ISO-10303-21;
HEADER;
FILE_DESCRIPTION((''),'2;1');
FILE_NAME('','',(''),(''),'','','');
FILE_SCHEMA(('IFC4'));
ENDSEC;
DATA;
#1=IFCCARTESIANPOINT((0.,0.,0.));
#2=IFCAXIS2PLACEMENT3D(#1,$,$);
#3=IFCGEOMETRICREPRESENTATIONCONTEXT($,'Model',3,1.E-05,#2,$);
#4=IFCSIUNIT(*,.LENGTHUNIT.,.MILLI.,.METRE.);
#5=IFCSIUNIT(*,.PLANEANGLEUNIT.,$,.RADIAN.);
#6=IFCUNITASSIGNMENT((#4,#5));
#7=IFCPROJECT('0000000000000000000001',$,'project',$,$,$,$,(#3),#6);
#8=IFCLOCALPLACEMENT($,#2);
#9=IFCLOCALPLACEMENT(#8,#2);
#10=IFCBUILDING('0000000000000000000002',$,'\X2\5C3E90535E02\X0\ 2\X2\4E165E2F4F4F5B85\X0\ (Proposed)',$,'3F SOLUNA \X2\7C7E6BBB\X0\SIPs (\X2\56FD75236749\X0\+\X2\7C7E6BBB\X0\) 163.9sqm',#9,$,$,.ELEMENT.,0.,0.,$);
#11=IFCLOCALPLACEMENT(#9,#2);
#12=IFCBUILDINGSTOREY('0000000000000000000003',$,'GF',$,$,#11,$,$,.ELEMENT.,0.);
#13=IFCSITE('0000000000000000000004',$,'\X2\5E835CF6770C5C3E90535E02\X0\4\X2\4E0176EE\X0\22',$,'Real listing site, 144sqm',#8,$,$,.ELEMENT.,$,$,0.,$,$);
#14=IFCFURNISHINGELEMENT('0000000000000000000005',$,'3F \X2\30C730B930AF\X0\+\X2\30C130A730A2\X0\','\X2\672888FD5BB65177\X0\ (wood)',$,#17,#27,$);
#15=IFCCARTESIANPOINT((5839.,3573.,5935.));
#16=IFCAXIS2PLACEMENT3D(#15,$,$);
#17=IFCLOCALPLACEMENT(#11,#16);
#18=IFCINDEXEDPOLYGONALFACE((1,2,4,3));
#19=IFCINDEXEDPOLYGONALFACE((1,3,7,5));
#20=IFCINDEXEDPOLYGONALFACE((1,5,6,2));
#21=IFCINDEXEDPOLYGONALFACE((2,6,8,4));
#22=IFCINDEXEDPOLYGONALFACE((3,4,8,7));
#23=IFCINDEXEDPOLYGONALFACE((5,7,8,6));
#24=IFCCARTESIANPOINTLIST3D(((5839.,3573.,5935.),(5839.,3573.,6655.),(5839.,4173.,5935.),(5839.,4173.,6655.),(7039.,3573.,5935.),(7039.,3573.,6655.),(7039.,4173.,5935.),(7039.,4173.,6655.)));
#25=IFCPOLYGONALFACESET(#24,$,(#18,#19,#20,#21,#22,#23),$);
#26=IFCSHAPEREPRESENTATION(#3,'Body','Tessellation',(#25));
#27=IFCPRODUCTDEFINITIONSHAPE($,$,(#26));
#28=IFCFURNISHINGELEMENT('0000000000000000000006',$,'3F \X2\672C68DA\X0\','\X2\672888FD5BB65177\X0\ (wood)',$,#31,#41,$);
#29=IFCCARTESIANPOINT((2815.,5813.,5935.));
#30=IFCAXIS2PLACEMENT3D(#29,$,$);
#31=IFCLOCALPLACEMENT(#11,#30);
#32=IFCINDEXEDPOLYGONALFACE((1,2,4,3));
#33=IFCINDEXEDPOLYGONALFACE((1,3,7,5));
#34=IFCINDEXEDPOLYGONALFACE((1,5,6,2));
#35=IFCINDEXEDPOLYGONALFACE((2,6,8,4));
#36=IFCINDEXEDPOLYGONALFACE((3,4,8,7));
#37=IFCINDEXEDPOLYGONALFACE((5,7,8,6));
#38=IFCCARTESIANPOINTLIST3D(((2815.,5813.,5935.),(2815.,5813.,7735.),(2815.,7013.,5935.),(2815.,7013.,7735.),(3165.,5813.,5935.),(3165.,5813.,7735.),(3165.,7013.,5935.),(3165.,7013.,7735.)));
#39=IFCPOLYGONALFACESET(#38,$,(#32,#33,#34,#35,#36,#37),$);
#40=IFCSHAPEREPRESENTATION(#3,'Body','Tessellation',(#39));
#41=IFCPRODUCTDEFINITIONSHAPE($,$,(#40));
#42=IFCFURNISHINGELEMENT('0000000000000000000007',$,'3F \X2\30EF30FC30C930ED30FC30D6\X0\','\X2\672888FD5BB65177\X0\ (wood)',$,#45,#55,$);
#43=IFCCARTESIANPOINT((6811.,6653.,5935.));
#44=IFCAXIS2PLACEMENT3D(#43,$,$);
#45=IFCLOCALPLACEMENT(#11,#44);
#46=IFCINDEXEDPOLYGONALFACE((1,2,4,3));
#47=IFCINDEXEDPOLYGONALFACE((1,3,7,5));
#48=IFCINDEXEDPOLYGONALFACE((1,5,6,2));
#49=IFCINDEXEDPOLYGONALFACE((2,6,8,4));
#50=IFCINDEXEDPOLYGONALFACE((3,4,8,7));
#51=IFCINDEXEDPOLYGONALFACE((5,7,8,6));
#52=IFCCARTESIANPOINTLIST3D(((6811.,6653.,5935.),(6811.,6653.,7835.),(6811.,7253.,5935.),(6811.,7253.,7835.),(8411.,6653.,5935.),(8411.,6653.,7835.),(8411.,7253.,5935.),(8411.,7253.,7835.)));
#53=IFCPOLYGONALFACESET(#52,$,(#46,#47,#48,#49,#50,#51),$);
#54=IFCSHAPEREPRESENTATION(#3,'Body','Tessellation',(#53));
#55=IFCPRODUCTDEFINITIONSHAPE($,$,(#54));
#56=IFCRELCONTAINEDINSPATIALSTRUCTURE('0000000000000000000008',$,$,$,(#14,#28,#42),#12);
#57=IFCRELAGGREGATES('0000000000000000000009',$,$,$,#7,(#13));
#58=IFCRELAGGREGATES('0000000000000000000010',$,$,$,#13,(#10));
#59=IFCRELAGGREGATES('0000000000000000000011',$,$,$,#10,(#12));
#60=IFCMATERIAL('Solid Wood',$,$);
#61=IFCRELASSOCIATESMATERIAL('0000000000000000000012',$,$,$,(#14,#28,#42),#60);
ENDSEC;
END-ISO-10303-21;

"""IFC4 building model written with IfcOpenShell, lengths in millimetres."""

from ifc_helpers import new_model, si_unit, frame, frame_2d, origin, place, context, project, spatial, rectangle, extrude, material, element, save


model = new_model("IFC4")

# Units and contexts
model_context = context("Model", 3, precision=1e-05, world=origin())
ifc_project = project(units=[si_unit("LENGTHUNIT", "METRE", prefix="MILLI"), si_unit("PLANEANGLEUNIT", "RADIAN")], contexts=[model_context])

# Site, building, storey
site_placement = place(None, origin())
site = spatial("IfcSite", under=ifc_project, at=site_placement, Name="広島県尾道市4丁目22", ObjectType="Real listing site, 144sqm", CompositionType="ELEMENT", RefElevation=0.0)
building_placement = place(site_placement, origin())
building = spatial("IfcBuilding", under=site, at=building_placement, Name="尾道市 2世帯住宅 (Proposed)", ObjectType="3F SOLUNA 籾殻SIPs (国産杉+籾殻) 163.9sqm", CompositionType="ELEMENT", ElevationOfRefHeight=0.0, ElevationOfTerrain=0.0)
storey_placement = place(building_placement, origin())
storey = spatial("IfcBuildingStorey", under=building, at=storey_placement, Name="GF", CompositionType="ELEMENT", Elevation=0.0)

# Shared definitions
ifc_material_1 = material(Name="Solid Wood")

# Furnishing elements
furnishing_1_placement = place(storey_placement, frame((5839.0, 3573.0, 5935.0)))
element("IfcFurnishingElement", 1, at=furnishing_1_placement, inside=storey, material=ifc_material_1, Name="3F デスク+チェア", Description="木製家具 (wood)", context=model_context, shape_type="SweptSolid", body=[
    extrude(rectangle(XDim=1200.0, YDim=600.0, at=frame_2d((600.0, 300.0))), frame((5839.0, 3573.0, 5935.0)), (0.0, 0.0, 1.0), 720.0),
])
furnishing_2_placement = place(storey_placement, frame((2815.0, 5813.0, 5935.0)))
element("IfcFurnishingElement", 2, at=furnishing_2_placement, inside=storey, material=ifc_material_1, Name="3F 本棚", Description="木製家具 (wood)", context=model_context, shape_type="SweptSolid", body=[
    extrude(rectangle(XDim=350.0, YDim=1200.0, at=frame_2d((175.0, 600.0))), frame((2815.0, 5813.0, 5935.0)), (0.0, 0.0, 1.0), 1800.0),
])
furnishing_3_placement = place(storey_placement, frame((6811.0, 6653.0, 5935.0)))
element("IfcFurnishingElement", 3, at=furnishing_3_placement, inside=storey, material=ifc_material_1, Name="3F ワードローブ", Description="木製家具 (wood)", context=model_context, shape_type="SweptSolid", body=[
    extrude(rectangle(XDim=1600.0, YDim=600.0, at=frame_2d((800.0, 300.0))), frame((6811.0, 6653.0, 5935.0)), (0.0, 0.0, 1.0), 1900.0),
])

save(model, "model.ifc")
